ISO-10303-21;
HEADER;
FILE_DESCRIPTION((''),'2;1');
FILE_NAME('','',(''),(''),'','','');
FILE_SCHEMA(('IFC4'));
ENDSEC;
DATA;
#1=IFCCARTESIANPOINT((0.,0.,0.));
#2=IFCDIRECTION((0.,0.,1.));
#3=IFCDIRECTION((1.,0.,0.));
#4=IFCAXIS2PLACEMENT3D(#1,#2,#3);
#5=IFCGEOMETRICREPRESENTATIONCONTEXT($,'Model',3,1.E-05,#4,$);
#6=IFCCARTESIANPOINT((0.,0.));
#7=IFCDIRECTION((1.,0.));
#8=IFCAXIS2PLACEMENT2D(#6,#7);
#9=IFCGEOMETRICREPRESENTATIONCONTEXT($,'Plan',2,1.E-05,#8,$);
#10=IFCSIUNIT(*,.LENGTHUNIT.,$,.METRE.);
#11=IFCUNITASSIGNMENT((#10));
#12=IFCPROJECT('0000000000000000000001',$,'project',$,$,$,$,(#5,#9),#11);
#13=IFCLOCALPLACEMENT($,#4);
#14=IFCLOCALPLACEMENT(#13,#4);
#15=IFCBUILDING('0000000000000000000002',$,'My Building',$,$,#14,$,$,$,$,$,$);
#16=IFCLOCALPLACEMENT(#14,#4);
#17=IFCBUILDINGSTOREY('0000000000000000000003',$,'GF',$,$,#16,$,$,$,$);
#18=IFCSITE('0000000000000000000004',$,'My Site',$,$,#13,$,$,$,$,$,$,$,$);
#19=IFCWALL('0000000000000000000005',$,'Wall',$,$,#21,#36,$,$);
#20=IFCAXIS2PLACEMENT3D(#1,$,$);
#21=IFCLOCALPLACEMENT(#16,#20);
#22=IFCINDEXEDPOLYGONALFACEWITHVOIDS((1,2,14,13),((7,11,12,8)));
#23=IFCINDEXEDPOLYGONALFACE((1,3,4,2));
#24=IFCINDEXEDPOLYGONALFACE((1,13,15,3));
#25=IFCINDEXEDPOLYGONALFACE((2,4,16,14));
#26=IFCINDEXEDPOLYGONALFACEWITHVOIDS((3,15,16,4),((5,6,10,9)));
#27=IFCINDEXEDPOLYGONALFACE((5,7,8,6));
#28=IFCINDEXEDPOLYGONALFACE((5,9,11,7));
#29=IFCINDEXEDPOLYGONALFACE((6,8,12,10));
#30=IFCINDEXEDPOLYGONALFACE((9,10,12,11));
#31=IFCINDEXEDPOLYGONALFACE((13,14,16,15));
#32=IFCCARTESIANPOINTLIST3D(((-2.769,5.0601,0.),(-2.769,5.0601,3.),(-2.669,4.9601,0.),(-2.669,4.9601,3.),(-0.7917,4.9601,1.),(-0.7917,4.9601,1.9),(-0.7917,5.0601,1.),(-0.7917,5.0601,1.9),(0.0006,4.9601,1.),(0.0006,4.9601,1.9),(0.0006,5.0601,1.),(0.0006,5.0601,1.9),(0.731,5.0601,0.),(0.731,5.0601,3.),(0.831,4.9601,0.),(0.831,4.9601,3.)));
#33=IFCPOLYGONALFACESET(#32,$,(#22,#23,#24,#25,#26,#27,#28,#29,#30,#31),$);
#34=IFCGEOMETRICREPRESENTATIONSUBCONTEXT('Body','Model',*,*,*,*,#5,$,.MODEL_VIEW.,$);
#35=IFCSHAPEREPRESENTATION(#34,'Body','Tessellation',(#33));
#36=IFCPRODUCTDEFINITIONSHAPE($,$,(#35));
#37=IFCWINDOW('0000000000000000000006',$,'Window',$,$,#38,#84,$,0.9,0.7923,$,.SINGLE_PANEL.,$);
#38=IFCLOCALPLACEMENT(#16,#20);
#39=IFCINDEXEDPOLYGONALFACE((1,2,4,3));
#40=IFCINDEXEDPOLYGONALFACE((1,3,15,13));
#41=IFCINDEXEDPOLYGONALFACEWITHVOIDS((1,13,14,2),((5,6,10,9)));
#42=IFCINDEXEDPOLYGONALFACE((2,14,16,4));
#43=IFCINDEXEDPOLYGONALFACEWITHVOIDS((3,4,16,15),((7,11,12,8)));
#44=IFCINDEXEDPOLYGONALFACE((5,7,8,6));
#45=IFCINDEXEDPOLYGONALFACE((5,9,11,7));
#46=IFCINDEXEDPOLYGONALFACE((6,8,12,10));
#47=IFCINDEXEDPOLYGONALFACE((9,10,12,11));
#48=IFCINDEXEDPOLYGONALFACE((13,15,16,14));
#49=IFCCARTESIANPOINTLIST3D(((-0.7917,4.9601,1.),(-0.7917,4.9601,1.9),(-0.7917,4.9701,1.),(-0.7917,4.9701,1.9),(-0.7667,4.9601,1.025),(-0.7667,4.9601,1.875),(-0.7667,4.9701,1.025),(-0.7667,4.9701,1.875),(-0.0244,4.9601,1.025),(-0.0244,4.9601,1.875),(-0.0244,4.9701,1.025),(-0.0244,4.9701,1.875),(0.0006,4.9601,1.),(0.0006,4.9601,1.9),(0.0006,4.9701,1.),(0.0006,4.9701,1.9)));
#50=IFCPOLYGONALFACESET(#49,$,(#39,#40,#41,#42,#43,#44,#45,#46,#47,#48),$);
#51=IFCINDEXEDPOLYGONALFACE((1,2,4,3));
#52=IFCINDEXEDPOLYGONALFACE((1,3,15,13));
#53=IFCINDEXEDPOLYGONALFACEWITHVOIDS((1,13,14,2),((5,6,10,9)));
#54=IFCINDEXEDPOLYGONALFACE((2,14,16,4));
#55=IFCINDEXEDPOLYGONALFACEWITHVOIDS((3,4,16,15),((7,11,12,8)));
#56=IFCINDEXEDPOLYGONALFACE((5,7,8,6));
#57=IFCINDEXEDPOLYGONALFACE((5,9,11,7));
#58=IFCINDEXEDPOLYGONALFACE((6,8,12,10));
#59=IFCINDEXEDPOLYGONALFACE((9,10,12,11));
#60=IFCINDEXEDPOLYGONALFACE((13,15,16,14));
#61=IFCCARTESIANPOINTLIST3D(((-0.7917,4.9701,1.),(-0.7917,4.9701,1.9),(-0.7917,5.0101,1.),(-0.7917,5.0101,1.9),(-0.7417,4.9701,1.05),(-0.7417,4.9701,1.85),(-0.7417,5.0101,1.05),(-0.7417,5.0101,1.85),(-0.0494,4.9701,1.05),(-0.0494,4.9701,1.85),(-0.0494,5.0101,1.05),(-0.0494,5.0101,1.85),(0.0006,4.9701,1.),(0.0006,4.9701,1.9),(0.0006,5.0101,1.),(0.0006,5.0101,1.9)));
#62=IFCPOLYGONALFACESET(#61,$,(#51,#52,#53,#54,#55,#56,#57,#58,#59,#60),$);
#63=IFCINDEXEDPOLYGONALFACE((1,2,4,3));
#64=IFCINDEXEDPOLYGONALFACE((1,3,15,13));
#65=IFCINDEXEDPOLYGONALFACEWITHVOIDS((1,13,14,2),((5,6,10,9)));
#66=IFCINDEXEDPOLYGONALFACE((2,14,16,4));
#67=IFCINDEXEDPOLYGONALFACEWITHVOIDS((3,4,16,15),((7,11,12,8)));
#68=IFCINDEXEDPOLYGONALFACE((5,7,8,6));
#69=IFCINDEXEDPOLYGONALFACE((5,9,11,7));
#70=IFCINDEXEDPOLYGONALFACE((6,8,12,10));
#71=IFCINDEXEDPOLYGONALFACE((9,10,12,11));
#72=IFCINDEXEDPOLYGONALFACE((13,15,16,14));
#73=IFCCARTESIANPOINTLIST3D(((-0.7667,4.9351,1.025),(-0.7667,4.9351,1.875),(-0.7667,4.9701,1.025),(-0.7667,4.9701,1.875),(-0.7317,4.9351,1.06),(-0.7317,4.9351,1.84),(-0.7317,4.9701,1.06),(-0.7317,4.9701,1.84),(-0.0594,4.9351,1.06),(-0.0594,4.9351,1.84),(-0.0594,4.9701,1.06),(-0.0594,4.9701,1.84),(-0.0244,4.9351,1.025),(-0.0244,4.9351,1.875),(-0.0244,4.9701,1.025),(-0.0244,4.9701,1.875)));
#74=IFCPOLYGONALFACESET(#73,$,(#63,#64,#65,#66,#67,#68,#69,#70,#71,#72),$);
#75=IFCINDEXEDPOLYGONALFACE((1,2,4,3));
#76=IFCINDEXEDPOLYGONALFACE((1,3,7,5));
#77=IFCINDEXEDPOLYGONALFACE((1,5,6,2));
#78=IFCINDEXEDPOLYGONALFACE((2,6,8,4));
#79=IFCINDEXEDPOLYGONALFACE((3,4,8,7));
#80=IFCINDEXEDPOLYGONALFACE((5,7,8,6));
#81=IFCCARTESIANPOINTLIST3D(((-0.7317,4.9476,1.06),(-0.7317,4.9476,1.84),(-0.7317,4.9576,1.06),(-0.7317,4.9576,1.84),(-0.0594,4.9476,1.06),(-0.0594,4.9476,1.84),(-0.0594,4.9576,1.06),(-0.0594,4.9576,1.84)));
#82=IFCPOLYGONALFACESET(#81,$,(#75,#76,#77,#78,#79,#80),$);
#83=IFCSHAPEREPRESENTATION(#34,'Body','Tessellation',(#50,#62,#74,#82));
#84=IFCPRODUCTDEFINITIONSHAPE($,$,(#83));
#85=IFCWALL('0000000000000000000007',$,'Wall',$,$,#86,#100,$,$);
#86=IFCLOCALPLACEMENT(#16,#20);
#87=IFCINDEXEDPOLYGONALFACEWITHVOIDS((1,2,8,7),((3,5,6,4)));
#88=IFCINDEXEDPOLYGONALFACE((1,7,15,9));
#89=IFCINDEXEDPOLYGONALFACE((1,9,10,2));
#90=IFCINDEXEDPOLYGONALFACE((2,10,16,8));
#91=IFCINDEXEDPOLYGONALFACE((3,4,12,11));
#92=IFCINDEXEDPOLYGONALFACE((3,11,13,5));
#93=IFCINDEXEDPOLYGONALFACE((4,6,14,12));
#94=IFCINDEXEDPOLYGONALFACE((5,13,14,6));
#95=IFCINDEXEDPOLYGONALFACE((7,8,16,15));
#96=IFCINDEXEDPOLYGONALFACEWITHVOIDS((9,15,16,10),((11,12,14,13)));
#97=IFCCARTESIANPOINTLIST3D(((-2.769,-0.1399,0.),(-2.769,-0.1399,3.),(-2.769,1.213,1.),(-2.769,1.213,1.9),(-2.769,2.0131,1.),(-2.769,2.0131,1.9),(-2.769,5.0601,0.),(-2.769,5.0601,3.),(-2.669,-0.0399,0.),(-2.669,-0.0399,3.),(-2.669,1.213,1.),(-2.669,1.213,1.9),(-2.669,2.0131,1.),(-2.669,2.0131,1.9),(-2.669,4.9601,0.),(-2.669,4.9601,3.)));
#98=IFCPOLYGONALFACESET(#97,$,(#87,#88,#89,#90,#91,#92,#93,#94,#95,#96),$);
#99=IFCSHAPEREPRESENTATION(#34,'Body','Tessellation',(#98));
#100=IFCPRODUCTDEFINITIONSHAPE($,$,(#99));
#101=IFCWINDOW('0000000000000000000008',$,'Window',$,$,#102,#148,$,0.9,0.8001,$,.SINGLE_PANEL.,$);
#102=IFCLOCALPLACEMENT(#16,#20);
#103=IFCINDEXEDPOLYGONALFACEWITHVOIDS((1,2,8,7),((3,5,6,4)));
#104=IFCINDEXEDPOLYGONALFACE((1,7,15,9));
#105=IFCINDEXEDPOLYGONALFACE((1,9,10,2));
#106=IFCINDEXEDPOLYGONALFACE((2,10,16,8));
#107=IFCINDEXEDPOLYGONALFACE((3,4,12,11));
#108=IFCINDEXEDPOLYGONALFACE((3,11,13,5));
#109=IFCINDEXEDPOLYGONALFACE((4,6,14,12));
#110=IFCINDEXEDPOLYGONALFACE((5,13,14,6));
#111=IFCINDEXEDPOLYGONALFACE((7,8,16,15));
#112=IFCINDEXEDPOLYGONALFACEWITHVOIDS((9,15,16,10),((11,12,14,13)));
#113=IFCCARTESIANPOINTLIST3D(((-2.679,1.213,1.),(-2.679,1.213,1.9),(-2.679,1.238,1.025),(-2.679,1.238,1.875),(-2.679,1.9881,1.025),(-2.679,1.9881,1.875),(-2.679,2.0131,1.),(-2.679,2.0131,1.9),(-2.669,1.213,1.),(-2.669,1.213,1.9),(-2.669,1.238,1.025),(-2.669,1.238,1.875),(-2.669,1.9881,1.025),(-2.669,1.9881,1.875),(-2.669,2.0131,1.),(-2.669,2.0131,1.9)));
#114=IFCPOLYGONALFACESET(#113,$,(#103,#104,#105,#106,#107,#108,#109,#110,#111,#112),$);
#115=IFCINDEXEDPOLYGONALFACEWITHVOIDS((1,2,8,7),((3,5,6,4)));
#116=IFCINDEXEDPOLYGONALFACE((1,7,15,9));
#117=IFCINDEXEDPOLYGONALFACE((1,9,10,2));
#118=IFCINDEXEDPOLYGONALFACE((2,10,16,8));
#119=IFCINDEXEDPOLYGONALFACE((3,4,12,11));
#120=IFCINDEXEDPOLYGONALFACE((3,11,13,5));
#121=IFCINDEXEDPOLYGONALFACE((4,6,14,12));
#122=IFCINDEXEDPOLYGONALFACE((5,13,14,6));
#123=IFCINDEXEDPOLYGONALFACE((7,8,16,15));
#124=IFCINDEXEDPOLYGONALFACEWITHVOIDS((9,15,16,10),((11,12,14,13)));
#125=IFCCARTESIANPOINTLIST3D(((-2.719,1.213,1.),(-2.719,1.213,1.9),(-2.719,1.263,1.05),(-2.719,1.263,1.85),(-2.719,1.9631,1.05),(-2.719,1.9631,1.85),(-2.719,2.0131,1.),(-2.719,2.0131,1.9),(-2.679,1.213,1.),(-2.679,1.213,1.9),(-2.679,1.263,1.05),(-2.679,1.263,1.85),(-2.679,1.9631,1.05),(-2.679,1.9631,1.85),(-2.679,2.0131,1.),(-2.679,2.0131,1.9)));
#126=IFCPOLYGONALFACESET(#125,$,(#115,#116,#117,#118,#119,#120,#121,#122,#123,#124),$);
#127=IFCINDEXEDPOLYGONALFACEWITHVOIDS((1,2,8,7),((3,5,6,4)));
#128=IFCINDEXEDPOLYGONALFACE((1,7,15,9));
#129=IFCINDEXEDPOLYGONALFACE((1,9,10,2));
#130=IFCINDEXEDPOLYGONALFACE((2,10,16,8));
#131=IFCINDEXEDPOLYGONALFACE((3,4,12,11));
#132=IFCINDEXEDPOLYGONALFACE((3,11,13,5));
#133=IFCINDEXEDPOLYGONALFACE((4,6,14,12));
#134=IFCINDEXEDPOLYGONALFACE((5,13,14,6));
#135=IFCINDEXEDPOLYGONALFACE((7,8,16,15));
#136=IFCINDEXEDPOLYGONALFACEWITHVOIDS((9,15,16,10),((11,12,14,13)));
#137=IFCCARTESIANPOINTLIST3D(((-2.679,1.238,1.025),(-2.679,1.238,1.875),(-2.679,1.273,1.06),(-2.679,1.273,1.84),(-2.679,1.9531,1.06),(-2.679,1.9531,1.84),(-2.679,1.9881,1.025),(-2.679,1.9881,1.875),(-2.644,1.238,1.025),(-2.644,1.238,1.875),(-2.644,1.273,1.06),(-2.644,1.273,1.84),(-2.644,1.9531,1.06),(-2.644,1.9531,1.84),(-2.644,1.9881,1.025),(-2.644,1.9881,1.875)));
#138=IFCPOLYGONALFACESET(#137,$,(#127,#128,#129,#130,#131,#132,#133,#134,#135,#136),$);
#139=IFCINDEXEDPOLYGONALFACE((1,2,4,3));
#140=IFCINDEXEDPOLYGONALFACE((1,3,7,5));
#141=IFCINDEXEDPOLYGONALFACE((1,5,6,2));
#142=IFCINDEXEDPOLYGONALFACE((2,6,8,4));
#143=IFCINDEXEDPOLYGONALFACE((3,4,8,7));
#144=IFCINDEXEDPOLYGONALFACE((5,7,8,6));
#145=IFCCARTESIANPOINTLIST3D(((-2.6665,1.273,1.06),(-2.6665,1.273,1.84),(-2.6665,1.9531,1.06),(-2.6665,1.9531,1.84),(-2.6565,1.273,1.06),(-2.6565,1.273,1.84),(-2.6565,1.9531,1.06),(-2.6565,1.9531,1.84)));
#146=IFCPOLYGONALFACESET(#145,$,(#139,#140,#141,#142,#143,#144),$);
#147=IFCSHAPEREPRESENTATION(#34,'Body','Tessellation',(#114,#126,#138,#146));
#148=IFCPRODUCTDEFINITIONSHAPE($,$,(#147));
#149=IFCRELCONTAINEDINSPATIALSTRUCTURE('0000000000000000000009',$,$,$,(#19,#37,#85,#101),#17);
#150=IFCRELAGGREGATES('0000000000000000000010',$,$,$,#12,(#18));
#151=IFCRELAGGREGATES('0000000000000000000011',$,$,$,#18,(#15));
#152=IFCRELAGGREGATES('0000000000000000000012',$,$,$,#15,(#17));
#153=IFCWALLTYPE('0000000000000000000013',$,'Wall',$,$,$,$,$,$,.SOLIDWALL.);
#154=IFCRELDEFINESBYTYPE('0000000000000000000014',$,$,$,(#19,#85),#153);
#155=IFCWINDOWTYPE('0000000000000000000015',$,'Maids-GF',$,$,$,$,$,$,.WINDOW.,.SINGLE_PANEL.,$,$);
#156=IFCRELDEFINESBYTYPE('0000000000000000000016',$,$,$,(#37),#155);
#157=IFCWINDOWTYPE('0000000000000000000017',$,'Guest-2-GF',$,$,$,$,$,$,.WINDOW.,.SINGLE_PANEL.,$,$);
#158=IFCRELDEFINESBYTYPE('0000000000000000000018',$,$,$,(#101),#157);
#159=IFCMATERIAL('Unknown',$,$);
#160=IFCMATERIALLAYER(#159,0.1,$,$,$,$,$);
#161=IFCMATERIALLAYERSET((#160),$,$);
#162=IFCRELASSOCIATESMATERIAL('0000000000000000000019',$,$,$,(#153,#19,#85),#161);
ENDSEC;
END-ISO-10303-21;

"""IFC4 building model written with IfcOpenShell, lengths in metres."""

from ifc_helpers import new_model, entity, si_unit, frame, origin_with_axes, origin_2d_with_axis, place, context, subcontext, project, spatial, line, indexed_curve, outline, extrude, shape, source, transform, mapped, material, layer, layer_set, layer_usage, type_object, type_shapes, element, fill, save


model = new_model("IFC4")

# Units and contexts
model_context = context("Model", 3, precision=1e-05, world=origin_with_axes())
plan_context = context("Plan", 2, precision=1e-05, world=origin_2d_with_axis())
body_context_1 = subcontext(model_context, "Body", "Model", "MODEL_VIEW")
body_context_2 = subcontext(plan_context, "Body", "Plan", "PLAN_VIEW")
ifc_project = project(units=[si_unit("LENGTHUNIT", "METRE")], contexts=[model_context, plan_context])

# Site, building, storey
site_placement = place(None, origin_with_axes())
site = spatial("IfcSite", under=ifc_project, at=site_placement, Name="My Site")
building_placement = place(site_placement, origin_with_axes())
building = spatial("IfcBuilding", under=site, at=building_placement, Name="My Building")
storey_placement = place(building_placement, origin_with_axes())
storey = spatial("IfcBuildingStorey", under=building, at=storey_placement, Name="GF")

# Shared definitions
ifc_material_1 = material(Name="Unknown")

# Shared definitions
ifc_layer_1 = layer(ifc_material_1, 0.1)
ifc_layer_set_1 = layer_set([ifc_layer_1])
wall_type = type_object("IfcWallType", Name="Wall", PredefinedType="SOLIDWALL", material=ifc_layer_set_1)

# Walls, openings, windows
ifc_layer_usage_1 = layer_usage(ifc_layer_set_1, "AXIS2", "POSITIVE", 0.0)
wall_1_placement = place(storey_placement, frame((0.731, 5.0601, 0.0), z_axis=(0.0, 0.0, 1.0), x_axis=(-1.0, 0.0, 0.0)))
wall_1 = element("IfcWall", 1, at=wall_1_placement, inside=storey, type_object=wall_type, material=ifc_layer_usage_1, Name="Wall", context=body_context_1, shape_type="SweptSolid", body=[
    extrude(outline(indexed_curve([(0.0, 0.0), (-0.1, 0.1), (3.4, 0.1), (3.5, 0.0)], segments=[line(1, 2, 3, 4, 1)])), origin_with_axes(), (0.0, 0.0, 1.0), 3.0),
])
shared_shape_1 = source(origin_with_axes(), body_context_1, "Body", "SweptSolid", [
    extrude(outline(indexed_curve([(0.0, 0.0), (0.7923, 0.0), (0.7923, 0.9), (0.0, 0.9)], segments=[line(1, 2, 3, 4, 1)])), frame((0.0, -0.6, 0.0), z_axis=(0.0, -1.0, 0.0), x_axis=(1.0, 0.0, 0.0)), (0.0, 0.0, -1.0), 1.2),
])
opening_1_placement = place(wall_1_placement, frame((0.7304, 0.0, 1.0), z_axis=(0.0, 0.0, 1.0), x_axis=(1.0, 0.0, 0.0)))
opening_1 = element("IfcOpeningElement", 2, at=opening_1_placement, cuts=wall_1, PredefinedType="OPENING", context=body_context_1, shape_type="MappedRepresentation", body=[
    mapped(shared_shape_1, transform((0.0, 0.0, 0.0), x_axis=(1.0, 0.0, 0.0), y_axis=(0.0, 1.0, 0.0), z_axis=(0.0, 0.0, 1.0), scale=1.0)),
])
window_type_1 = type_object("IfcWindowType", Name="Maids-GF", PartitioningType="SINGLE_PANEL", PredefinedType="WINDOW")
shared_shape_2 = source(origin_with_axes(), body_context_1, "Body", "SweptSolid", [
    extrude(outline(indexed_curve([(0.0, 0.0), (0.7923, 0.0), (0.7923, 0.9), (0.0, 0.9)], segments=[line(1, 2, 3, 4, 1)]), holes=[indexed_curve([(0.025, 0.025), (0.7673, 0.025), (0.7673, 0.875), (0.025, 0.875)], segments=[line(1, 2, 3, 4, 1)])]), frame((0.0, 0.09, 0.0), z_axis=(0.0, -1.0, 0.0), x_axis=(1.0, 0.0, 0.0)), (0.0, 0.0, -1.0), 0.01),
    extrude(outline(indexed_curve([(0.0, 0.0), (0.7923, 0.0), (0.7923, 0.9), (0.0, 0.9)], segments=[line(1, 2, 3, 4, 1)]), holes=[indexed_curve([(0.05, 0.05), (0.7423, 0.05), (0.7423, 0.85), (0.05, 0.85)], segments=[line(1, 2, 3, 4, 1)])]), frame((0.0, 0.05, 0.0), z_axis=(0.0, -1.0, 0.0), x_axis=(1.0, 0.0, 0.0)), (0.0, 0.0, -1.0), 0.04),
    extrude(outline(indexed_curve([(0.0, 0.0), (0.7423, 0.0), (0.7423, 0.85), (0.0, 0.85)], segments=[line(1, 2, 3, 4, 1)]), holes=[indexed_curve([(0.035, 0.035), (0.7073, 0.035), (0.7073, 0.815), (0.035, 0.815)], segments=[line(1, 2, 3, 4, 1)])]), frame((0.025, 0.09, 0.025), z_axis=(0.0, -1.0, 0.0), x_axis=(1.0, 0.0, 0.0)), (0.0, 0.0, -1.0), 0.035),
    extrude(outline(indexed_curve([(0.035, 0.035), (0.7073, 0.035), (0.7073, 0.815), (0.035, 0.815)], segments=[line(1, 2, 3, 4, 1)])), frame((0.025, 0.1025, 0.025), z_axis=(0.0, -1.0, 0.0), x_axis=(1.0, 0.0, 0.0)), (0.0, 0.0, -1.0), 0.01),
])
shared_shape_3 = source(origin_with_axes(), body_context_2, "Body", "Curve2D", [
    entity("IfcIndexedPolyCurve", entity("IfcCartesianPointList2D", [[0.05, 0.05], [0.7423, 0.05]])),
    entity("IfcIndexedPolyCurve", entity("IfcCartesianPointList2D", [[0.0, 0.1], [0.025, 0.1], [0.025, 0.09], [0.05, 0.09], [0.05, 0.05], [0.0, 0.05]]), [entity("IfcLineIndex", [1, 2, 3, 4, 5, 6, 1])]),
    entity("IfcIndexedPolyCurve", entity("IfcCartesianPointList2D", [[0.7923, 0.1], [0.7673, 0.1], [0.7673, 0.09], [0.7423, 0.09], [0.7423, 0.05], [0.7923, 0.05]]), [entity("IfcLineIndex", [1, 2, 3, 4, 5, 6, 1])]),
    entity("IfcIndexedPolyCurve", entity("IfcCartesianPointList2D", [[0.025, 0.09], [0.06, 0.09], [0.06, 0.125], [0.025, 0.125]]), [entity("IfcLineIndex", [1, 2, 3, 4, 1])]),
    entity("IfcIndexedPolyCurve", entity("IfcCartesianPointList2D", [[0.7673, 0.09], [0.7323, 0.09], [0.7323, 0.125], [0.7673, 0.125]]), [entity("IfcLineIndex", [1, 2, 3, 4, 1])]),
    entity("IfcIndexedPolyCurve", entity("IfcCartesianPointList2D", [[0.06, 0.09], [0.7323, 0.09]])),
    entity("IfcIndexedPolyCurve", entity("IfcCartesianPointList2D", [[0.06, 0.125], [0.7323, 0.125]])),
    entity("IfcIndexedPolyCurve", entity("IfcCartesianPointList2D", [[0.06, 0.1075], [0.7323, 0.1075]])),
])
type_shapes(window_type_1, [shared_shape_2, shared_shape_3])
window_1_placement = place(opening_1_placement, frame((0.0, 0.0, 0.0), z_axis=(0.0, 0.0, 1.0), x_axis=(1.0, 0.0, 0.0)))
window_1 = element("IfcWindow", 3, at=window_1_placement, inside=storey, type_object=window_type_1, Name="Window", OverallHeight=0.9, OverallWidth=0.7923, PartitioningType="SINGLE_PANEL", shapes=[
    shape(body_context_1, "Body", "MappedRepresentation", [mapped(shared_shape_2, transform((0.0, 0.0, 0.0), x_axis=(1.0, 0.0, 0.0), y_axis=(0.0, 1.0, 0.0), z_axis=(0.0, 0.0, 1.0), scale=1.0))]),
    shape(body_context_2, "Body", "MappedRepresentation", [mapped(shared_shape_3, transform((0.0, 0.0, 0.0), x_axis=(1.0, 0.0, 0.0), y_axis=(0.0, 1.0, 0.0), z_axis=(0.0, 0.0, 1.0), scale=1.0))]),
])
fill(opening_1, window_1)
ifc_layer_usage_2 = layer_usage(ifc_layer_set_1, "AXIS2", "POSITIVE", 0.0)
wall_2_placement = place(storey_placement, frame((-2.769, 5.0601, 0.0), z_axis=(0.0, 0.0, 1.0), x_axis=(0.0, -1.0, 0.0)))
wall_2 = element("IfcWall", 4, at=wall_2_placement, inside=storey, type_object=wall_type, material=ifc_layer_usage_2, Name="Wall", context=body_context_1, shape_type="SweptSolid", body=[
    extrude(outline(indexed_curve([(0.0, 0.0), (0.1, 0.1), (5.1, 0.1), (5.2, 0.0)], segments=[line(1, 2, 3, 4, 1)])), origin_with_axes(), (0.0, 0.0, 1.0), 3.0),
])
shared_shape_4 = source(origin_with_axes(), body_context_1, "Body", "SweptSolid", [
    extrude(outline(indexed_curve([(0.0, 0.0), (0.8001, 0.0), (0.8001, 0.9), (0.0, 0.9)], segments=[line(1, 2, 3, 4, 1)])), frame((0.0, -0.6, 0.0), z_axis=(0.0, -1.0, 0.0), x_axis=(1.0, 0.0, 0.0)), (0.0, 0.0, -1.0), 1.2),
])
opening_2_placement = place(wall_2_placement, frame((3.047, 0.0, 1.0), z_axis=(0.0, 0.0, 1.0), x_axis=(1.0, 0.0, 0.0)))
opening_2 = element("IfcOpeningElement", 5, at=opening_2_placement, cuts=wall_2, PredefinedType="OPENING", context=body_context_1, shape_type="MappedRepresentation", body=[
    mapped(shared_shape_4, transform((0.0, 0.0, 0.0), x_axis=(1.0, 0.0, 0.0), y_axis=(0.0, 1.0, 0.0), z_axis=(0.0, 0.0, 1.0), scale=1.0)),
])
window_type_2 = type_object("IfcWindowType", Name="Guest-2-GF", PartitioningType="SINGLE_PANEL", PredefinedType="WINDOW")
shared_shape_5 = source(origin_with_axes(), body_context_1, "Body", "SweptSolid", [
    extrude(outline(indexed_curve([(0.0, 0.0), (0.8001, 0.0), (0.8001, 0.9), (0.0, 0.9)], segments=[line(1, 2, 3, 4, 1)]), holes=[indexed_curve([(0.025, 0.025), (0.7751, 0.025), (0.7751, 0.875), (0.025, 0.875)], segments=[line(1, 2, 3, 4, 1)])]), frame((0.0, 0.09, 0.0), z_axis=(0.0, -1.0, 0.0), x_axis=(1.0, 0.0, 0.0)), (0.0, 0.0, -1.0), 0.01),
    extrude(outline(indexed_curve([(0.0, 0.0), (0.8001, 0.0), (0.8001, 0.9), (0.0, 0.9)], segments=[line(1, 2, 3, 4, 1)]), holes=[indexed_curve([(0.05, 0.05), (0.7501, 0.05), (0.7501, 0.85), (0.05, 0.85)], segments=[line(1, 2, 3, 4, 1)])]), frame((0.0, 0.05, 0.0), z_axis=(0.0, -1.0, 0.0), x_axis=(1.0, 0.0, 0.0)), (0.0, 0.0, -1.0), 0.04),
    extrude(outline(indexed_curve([(0.0, 0.0), (0.7501, 0.0), (0.7501, 0.85), (0.0, 0.85)], segments=[line(1, 2, 3, 4, 1)]), holes=[indexed_curve([(0.035, 0.035), (0.7151, 0.035), (0.7151, 0.815), (0.035, 0.815)], segments=[line(1, 2, 3, 4, 1)])]), frame((0.025, 0.09, 0.025), z_axis=(0.0, -1.0, 0.0), x_axis=(1.0, 0.0, 0.0)), (0.0, 0.0, -1.0), 0.035),
    extrude(outline(indexed_curve([(0.035, 0.035), (0.7151, 0.035), (0.7151, 0.815), (0.035, 0.815)], segments=[line(1, 2, 3, 4, 1)])), frame((0.025, 0.1025, 0.025), z_axis=(0.0, -1.0, 0.0), x_axis=(1.0, 0.0, 0.0)), (0.0, 0.0, -1.0), 0.01),
])
shared_shape_6 = source(origin_with_axes(), body_context_2, "Body", "Curve2D", [
    entity("IfcIndexedPolyCurve", entity("IfcCartesianPointList2D", [[0.05, 0.05], [0.7501, 0.05]])),
    entity("IfcIndexedPolyCurve", entity("IfcCartesianPointList2D", [[0.0, 0.1], [0.025, 0.1], [0.025, 0.09], [0.05, 0.09], [0.05, 0.05], [0.0, 0.05]]), [entity("IfcLineIndex", [1, 2, 3, 4, 5, 6, 1])]),
    entity("IfcIndexedPolyCurve", entity("IfcCartesianPointList2D", [[0.8001, 0.1], [0.7751, 0.1], [0.7751, 0.09], [0.7501, 0.09], [0.7501, 0.05], [0.8001, 0.05]]), [entity("IfcLineIndex", [1, 2, 3, 4, 5, 6, 1])]),
    entity("IfcIndexedPolyCurve", entity("IfcCartesianPointList2D", [[0.025, 0.09], [0.06, 0.09], [0.06, 0.125], [0.025, 0.125]]), [entity("IfcLineIndex", [1, 2, 3, 4, 1])]),
    entity("IfcIndexedPolyCurve", entity("IfcCartesianPointList2D", [[0.7751, 0.09], [0.7401, 0.09], [0.7401, 0.125], [0.7751, 0.125]]), [entity("IfcLineIndex", [1, 2, 3, 4, 1])]),
    entity("IfcIndexedPolyCurve", entity("IfcCartesianPointList2D", [[0.06, 0.09], [0.7401, 0.09]])),
    entity("IfcIndexedPolyCurve", entity("IfcCartesianPointList2D", [[0.06, 0.125], [0.7401, 0.125]])),
    entity("IfcIndexedPolyCurve", entity("IfcCartesianPointList2D", [[0.06, 0.1075], [0.7401, 0.1075]])),
])
type_shapes(window_type_2, [shared_shape_5, shared_shape_6])
window_2_placement = place(opening_2_placement, frame((0.0, 0.0, 0.0), z_axis=(0.0, 0.0, 1.0), x_axis=(1.0, 0.0, 0.0)))
window_2 = element("IfcWindow", 6, at=window_2_placement, inside=storey, type_object=window_type_2, Name="Window", OverallHeight=0.9, OverallWidth=0.8001, PartitioningType="SINGLE_PANEL", shapes=[
    shape(body_context_1, "Body", "MappedRepresentation", [mapped(shared_shape_5, transform((0.0, 0.0, 0.0), x_axis=(1.0, 0.0, 0.0), y_axis=(0.0, 1.0, 0.0), z_axis=(0.0, 0.0, 1.0), scale=1.0))]),
    shape(body_context_2, "Body", "MappedRepresentation", [mapped(shared_shape_6, transform((0.0, 0.0, 0.0), x_axis=(1.0, 0.0, 0.0), y_axis=(0.0, 1.0, 0.0), z_axis=(0.0, 0.0, 1.0), scale=1.0))]),
])
fill(opening_2, window_2)

save(model, "model.ifc")
